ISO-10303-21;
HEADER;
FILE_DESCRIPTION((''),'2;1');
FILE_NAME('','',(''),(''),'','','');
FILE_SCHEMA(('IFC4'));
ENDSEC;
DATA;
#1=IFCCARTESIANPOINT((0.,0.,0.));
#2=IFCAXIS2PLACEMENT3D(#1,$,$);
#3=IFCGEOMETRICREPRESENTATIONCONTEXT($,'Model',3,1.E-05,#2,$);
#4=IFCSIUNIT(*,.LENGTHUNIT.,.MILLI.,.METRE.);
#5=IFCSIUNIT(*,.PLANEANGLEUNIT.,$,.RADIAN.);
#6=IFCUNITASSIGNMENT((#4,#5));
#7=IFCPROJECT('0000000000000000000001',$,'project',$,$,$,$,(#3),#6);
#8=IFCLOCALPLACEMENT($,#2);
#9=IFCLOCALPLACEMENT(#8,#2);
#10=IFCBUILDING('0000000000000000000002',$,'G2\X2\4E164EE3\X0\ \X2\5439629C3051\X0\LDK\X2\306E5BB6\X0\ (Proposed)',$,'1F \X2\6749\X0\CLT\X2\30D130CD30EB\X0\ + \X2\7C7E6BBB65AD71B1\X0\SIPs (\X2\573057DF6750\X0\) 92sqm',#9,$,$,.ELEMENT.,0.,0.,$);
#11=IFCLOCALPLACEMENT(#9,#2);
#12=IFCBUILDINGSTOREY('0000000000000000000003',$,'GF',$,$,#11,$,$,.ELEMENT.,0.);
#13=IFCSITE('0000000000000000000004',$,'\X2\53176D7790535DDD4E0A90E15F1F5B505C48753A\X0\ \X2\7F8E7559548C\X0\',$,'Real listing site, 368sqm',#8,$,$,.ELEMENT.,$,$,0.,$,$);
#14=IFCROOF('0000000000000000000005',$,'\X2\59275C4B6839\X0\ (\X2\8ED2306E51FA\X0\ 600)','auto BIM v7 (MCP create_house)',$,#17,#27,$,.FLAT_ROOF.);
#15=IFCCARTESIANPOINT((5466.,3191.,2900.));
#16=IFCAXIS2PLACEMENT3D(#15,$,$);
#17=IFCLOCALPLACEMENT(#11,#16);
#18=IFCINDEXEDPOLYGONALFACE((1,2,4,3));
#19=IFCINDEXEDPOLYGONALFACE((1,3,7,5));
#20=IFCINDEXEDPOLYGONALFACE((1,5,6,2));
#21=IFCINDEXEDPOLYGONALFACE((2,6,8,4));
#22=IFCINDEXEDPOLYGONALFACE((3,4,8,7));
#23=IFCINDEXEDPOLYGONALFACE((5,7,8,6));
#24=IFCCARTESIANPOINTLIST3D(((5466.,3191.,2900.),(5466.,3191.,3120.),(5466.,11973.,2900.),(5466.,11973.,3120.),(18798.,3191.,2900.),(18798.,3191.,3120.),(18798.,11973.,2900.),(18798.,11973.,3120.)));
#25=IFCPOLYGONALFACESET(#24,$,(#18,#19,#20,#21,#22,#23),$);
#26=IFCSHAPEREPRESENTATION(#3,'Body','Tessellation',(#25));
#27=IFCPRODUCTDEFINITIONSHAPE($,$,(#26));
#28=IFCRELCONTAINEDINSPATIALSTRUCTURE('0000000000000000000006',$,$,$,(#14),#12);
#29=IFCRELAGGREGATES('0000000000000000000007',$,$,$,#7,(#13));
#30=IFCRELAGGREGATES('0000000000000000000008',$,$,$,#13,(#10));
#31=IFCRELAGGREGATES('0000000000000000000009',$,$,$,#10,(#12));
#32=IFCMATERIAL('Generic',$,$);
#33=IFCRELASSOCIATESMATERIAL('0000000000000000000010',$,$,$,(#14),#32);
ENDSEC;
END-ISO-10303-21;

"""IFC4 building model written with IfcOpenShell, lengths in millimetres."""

from ifc_helpers import new_model, si_unit, frame, frame_2d, origin, place, context, project, spatial, rectangle, extrude, material, element, save


model = new_model("IFC4")

# Units and contexts
model_context = context("Model", 3, precision=1e-05, world=origin())
ifc_project = project(units=[si_unit("LENGTHUNIT", "METRE", prefix="MILLI"), si_unit("PLANEANGLEUNIT", "RADIAN")], contexts=[model_context])

# Site, building, storey
site_placement = place(None, origin())
site = spatial("IfcSite", under=ifc_project, at=site_placement, Name="北海道川上郡弟子屈町 美留和", ObjectType="Real listing site, 368sqm", CompositionType="ELEMENT", RefElevation=0.0)
building_placement = place(site_placement, origin())
building = spatial("IfcBuilding", under=site, at=building_placement, Name="G2世代 吹抜けLDKの家 (Proposed)", ObjectType="1F 杉CLTパネル + 籾殻断熱SIPs (地域材) 92sqm", CompositionType="ELEMENT", ElevationOfRefHeight=0.0, ElevationOfTerrain=0.0)
storey_placement = place(building_placement, origin())
storey = spatial("IfcBuildingStorey", under=building, at=storey_placement, Name="GF", CompositionType="ELEMENT", Elevation=0.0)

# Shared definitions
ifc_material = material(Name="Generic")

# Roof
roof_placement = place(storey_placement, frame((5466.0, 3191.0, 2900.0)))
element("IfcRoof", 1, at=roof_placement, inside=storey, material=ifc_material, Name="大屋根 (軒の出 600)", Description="auto BIM v7 (MCP create_house)", PredefinedType="FLAT_ROOF", context=model_context, shape_type="SweptSolid", body=[
    extrude(rectangle(XDim=13332.0, YDim=8782.0, at=frame_2d((6666.0, 4391.0))), frame((5466.0, 3191.0, 2900.0)), (0.0, 0.0, 1.0), 220.0),
])

save(model, "model.ifc")
